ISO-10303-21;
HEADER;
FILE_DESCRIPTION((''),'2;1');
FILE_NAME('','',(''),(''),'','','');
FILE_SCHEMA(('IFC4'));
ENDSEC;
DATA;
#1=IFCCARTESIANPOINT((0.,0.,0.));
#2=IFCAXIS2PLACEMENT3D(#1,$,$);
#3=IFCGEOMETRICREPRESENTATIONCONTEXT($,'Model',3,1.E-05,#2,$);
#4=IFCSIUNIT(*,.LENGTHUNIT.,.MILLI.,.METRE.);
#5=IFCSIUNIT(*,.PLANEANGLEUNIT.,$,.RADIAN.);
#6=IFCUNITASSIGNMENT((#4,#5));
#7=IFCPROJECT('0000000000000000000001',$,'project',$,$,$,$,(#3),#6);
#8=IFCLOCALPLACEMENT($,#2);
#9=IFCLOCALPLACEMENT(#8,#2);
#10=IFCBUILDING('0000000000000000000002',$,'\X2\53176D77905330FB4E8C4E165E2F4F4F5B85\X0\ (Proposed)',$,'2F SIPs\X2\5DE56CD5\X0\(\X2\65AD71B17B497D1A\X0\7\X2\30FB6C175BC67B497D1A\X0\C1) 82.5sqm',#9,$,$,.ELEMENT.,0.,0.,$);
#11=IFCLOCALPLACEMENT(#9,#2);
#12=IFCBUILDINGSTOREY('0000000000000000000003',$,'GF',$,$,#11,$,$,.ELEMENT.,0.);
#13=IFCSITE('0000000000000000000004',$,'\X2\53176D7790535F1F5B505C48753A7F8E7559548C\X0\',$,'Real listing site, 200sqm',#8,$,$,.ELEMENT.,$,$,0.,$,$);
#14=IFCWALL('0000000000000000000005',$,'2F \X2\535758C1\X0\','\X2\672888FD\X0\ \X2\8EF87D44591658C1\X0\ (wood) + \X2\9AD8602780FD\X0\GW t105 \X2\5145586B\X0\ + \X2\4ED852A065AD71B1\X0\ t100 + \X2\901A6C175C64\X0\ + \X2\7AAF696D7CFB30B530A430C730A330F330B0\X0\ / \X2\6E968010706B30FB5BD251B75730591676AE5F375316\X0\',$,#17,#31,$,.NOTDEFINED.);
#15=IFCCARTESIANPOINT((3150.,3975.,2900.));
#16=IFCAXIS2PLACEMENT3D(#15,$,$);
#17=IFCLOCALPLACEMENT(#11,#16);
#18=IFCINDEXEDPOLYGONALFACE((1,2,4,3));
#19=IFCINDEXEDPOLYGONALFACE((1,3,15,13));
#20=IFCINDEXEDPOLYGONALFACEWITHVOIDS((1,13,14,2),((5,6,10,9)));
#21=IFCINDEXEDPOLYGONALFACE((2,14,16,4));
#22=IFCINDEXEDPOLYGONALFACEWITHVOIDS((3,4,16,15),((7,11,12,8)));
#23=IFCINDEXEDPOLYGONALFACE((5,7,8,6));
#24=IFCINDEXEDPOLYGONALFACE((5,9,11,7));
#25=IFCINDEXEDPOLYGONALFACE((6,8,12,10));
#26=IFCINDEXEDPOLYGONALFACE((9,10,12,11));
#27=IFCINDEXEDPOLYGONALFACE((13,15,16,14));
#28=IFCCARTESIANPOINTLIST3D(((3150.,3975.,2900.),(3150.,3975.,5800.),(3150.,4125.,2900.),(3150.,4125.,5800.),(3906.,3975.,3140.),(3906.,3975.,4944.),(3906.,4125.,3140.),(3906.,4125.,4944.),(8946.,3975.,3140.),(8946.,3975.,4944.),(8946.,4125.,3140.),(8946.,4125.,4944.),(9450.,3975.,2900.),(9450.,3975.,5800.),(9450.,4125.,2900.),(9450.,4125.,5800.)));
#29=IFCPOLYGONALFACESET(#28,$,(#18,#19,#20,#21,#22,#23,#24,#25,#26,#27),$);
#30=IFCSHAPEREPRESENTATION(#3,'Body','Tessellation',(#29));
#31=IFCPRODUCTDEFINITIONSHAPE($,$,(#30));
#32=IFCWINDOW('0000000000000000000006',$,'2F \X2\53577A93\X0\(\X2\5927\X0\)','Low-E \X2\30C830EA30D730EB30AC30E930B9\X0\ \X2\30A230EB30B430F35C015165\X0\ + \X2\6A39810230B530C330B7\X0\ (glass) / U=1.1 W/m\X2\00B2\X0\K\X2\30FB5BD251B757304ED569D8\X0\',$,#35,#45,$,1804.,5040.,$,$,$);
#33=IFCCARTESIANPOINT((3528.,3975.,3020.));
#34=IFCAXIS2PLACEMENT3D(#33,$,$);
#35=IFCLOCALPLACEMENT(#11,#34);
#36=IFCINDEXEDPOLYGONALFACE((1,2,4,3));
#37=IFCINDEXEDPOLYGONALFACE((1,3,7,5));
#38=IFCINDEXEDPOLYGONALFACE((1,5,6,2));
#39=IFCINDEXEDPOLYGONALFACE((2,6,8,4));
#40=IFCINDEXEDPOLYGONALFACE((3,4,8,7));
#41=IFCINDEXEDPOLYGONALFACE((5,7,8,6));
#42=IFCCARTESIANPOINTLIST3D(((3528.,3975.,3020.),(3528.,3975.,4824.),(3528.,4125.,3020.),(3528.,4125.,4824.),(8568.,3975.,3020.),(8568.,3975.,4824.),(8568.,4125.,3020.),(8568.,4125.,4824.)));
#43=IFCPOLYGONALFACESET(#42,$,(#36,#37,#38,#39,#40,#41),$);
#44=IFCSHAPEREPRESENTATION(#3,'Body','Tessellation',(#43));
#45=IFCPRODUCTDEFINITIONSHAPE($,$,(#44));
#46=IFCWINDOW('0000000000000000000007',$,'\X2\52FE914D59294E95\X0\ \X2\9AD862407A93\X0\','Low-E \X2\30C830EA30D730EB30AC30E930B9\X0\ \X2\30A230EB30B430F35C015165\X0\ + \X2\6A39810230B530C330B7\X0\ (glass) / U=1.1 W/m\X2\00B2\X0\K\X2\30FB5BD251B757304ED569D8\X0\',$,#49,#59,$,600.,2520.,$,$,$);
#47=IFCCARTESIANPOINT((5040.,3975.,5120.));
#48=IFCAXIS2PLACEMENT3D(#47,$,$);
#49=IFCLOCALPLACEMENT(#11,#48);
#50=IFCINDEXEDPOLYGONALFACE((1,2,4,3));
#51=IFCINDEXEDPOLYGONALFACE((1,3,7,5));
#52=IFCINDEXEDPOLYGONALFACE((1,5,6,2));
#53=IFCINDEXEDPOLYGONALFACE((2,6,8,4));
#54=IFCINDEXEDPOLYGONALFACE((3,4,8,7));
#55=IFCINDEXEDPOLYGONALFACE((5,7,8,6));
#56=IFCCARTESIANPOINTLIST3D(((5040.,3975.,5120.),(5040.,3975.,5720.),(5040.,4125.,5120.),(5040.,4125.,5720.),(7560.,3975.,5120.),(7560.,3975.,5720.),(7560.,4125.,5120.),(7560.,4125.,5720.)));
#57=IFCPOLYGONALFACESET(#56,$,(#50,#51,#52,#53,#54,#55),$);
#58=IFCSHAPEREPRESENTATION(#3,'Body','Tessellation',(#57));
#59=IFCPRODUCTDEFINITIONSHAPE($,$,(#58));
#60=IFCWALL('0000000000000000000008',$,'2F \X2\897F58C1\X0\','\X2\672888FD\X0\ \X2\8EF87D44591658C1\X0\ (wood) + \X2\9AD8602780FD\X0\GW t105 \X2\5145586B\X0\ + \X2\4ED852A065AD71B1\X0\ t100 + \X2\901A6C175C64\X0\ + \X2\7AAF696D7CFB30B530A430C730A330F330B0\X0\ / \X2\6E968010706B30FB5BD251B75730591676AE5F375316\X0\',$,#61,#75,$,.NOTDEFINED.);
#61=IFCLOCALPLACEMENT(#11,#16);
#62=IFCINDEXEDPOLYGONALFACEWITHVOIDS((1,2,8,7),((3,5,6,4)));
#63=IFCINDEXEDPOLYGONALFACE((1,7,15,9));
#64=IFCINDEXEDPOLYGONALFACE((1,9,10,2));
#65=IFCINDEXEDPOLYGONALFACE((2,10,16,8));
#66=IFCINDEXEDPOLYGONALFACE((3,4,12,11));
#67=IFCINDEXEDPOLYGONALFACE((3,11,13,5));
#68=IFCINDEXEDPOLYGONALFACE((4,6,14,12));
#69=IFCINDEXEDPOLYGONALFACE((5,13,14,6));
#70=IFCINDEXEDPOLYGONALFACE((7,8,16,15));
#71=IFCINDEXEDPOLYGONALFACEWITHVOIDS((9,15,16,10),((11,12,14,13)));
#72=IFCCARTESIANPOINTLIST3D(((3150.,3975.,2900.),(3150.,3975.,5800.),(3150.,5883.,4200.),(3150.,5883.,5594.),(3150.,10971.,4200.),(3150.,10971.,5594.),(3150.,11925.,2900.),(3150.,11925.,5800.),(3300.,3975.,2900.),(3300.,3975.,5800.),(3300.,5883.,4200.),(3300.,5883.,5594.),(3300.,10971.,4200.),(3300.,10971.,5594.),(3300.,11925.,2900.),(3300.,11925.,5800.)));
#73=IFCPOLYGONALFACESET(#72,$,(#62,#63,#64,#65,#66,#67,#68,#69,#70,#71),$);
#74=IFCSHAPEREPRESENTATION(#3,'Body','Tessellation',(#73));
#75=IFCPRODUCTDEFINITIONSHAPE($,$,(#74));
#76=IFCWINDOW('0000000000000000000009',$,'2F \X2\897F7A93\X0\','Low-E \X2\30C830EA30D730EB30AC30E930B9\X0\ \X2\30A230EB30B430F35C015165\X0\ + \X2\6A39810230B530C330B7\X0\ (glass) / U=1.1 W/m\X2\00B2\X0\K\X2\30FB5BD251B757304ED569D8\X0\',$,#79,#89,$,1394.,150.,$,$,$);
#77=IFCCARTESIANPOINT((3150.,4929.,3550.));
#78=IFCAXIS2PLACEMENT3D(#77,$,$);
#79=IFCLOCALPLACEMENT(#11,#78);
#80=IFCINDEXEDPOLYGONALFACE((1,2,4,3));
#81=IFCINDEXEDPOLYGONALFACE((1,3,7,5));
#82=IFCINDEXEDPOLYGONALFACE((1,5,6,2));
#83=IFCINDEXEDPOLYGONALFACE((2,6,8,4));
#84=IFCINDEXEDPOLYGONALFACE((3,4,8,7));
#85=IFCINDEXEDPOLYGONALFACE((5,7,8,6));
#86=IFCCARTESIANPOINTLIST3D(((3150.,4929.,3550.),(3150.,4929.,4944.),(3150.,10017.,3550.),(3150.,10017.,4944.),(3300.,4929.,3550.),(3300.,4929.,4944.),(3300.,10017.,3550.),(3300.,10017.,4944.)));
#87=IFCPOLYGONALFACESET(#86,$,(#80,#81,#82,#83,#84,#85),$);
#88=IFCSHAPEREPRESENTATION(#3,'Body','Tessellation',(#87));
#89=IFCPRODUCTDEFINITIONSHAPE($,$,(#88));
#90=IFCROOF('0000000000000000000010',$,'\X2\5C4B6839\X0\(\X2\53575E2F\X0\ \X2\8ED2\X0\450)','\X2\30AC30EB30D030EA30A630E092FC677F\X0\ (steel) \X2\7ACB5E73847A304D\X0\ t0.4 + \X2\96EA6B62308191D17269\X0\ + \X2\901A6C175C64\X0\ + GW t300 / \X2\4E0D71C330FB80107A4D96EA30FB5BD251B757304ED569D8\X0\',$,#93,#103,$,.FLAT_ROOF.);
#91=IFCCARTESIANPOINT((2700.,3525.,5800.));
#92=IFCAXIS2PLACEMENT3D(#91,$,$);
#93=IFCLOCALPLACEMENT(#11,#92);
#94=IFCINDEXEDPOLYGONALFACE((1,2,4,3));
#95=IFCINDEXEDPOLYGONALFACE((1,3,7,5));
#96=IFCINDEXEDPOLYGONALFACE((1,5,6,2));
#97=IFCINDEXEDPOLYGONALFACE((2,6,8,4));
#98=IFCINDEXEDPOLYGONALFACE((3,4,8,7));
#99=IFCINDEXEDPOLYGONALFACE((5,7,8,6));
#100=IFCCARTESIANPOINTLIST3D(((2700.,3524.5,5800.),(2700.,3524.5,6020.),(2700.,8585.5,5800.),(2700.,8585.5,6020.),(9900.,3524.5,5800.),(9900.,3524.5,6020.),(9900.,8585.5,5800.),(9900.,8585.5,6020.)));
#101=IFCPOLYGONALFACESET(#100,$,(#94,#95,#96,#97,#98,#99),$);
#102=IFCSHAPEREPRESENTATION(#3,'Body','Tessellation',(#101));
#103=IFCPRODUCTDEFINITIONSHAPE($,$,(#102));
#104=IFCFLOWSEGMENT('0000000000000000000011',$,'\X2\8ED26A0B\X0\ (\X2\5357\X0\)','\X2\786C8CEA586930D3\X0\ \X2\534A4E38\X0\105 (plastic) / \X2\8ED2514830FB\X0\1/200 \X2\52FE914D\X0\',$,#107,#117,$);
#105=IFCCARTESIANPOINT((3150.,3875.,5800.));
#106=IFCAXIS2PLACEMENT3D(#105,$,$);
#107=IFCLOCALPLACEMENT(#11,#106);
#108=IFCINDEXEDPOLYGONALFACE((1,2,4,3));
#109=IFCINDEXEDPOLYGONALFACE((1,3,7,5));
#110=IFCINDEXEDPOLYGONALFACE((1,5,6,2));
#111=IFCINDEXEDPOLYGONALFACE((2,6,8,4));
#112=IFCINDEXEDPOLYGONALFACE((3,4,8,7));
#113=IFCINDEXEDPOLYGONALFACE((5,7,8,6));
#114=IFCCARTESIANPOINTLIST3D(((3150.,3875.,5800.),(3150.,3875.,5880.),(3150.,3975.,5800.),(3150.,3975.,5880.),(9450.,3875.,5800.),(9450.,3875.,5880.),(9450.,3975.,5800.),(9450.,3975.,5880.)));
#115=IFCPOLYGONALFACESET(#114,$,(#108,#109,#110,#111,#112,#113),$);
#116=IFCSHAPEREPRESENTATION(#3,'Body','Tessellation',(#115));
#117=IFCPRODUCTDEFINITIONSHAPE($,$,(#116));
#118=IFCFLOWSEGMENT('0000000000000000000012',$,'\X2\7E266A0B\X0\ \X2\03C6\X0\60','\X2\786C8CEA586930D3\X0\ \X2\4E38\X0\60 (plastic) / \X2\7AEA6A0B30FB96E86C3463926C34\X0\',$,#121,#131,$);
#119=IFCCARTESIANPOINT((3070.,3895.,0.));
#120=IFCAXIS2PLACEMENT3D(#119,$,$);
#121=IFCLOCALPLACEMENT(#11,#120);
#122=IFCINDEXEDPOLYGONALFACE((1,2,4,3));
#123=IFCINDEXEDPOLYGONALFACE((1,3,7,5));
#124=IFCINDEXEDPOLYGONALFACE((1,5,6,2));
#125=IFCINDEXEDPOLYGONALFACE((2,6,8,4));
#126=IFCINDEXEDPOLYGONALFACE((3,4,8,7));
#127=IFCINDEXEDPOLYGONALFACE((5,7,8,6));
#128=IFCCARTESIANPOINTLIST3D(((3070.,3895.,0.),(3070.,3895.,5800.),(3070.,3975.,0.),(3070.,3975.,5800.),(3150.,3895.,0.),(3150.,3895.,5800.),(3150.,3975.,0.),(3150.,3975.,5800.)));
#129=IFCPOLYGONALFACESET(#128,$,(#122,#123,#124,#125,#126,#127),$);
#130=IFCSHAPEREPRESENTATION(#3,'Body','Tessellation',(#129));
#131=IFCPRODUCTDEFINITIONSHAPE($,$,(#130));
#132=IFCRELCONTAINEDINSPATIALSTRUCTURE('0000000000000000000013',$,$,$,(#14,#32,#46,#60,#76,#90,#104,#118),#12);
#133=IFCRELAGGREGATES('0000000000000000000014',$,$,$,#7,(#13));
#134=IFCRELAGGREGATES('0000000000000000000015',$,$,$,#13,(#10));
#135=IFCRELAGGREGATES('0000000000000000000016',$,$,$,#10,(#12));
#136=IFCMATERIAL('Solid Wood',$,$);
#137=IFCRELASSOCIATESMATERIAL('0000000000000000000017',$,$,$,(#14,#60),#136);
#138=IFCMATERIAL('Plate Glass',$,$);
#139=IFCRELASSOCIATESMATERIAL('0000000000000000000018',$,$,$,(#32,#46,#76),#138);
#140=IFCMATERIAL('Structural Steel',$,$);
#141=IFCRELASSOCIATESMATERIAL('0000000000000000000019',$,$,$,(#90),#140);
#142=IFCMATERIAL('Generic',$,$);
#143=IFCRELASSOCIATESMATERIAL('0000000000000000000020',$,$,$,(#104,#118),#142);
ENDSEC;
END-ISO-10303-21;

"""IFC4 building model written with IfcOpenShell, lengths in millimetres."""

from ifc_helpers import new_model, si_unit, frame, frame_2d, origin, place, context, project, spatial, rectangle, extrude, material, element, fill, save


model = new_model("IFC4")

# Units and contexts
model_context = context("Model", 3, precision=1e-05, world=origin())
ifc_project = project(units=[si_unit("LENGTHUNIT", "METRE", prefix="MILLI"), si_unit("PLANEANGLEUNIT", "RADIAN")], contexts=[model_context])

# Site, building, storey
site_placement = place(None, origin())
site = spatial("IfcSite", under=ifc_project, at=site_placement, Name="北海道弟子屈町美留和", ObjectType="Real listing site, 200sqm", CompositionType="ELEMENT", RefElevation=0.0)
building_placement = place(site_placement, origin())
building = spatial("IfcBuilding", under=site, at=building_placement, Name="北海道・二世帯住宅 (Proposed)", ObjectType="2F SIPs工法(断熱等級7・気密等級C1) 82.5sqm", CompositionType="ELEMENT", ElevationOfRefHeight=0.0, ElevationOfTerrain=0.0)
storey_placement = place(building_placement, origin())
storey = spatial("IfcBuildingStorey", under=building, at=storey_placement, Name="GF", CompositionType="ELEMENT", Elevation=0.0)

# Shared definitions
ifc_material_1 = material(Name="Solid Wood")

# Shared definitions
ifc_material_2 = material(Name="Plate Glass")

# Wall, openings, windows
wall_1_placement = place(storey_placement, frame((3150.0, 3975.0, 2900.0)))
wall_1 = element("IfcWall", 1, at=wall_1_placement, inside=storey, material=ifc_material_1, Name="2F 南壁", Description="木製 軸組外壁 (wood) + 高性能GW t105 充填 + 付加断熱 t100 + 通気層 + 窯業系サイディング / 準耐火・寒冷地外皮強化", PredefinedType="NOTDEFINED", context=model_context, shape_type="SweptSolid", body=[
    extrude(rectangle(XDim=6300.0, YDim=150.0, at=frame_2d((3150.0, 75.0))), frame((3150.0, 3975.0, 2900.0)), (0.0, 0.0, 1.0), 2900.0),
])
opening_1_placement = place(storey_placement, frame((3528.0, 3975.0, 3020.0)))
opening_1 = element("IfcOpeningElement", 2, at=opening_1_placement, cuts=wall_1, PredefinedType="NOTDEFINED", context=model_context, shape_type="SweptSolid", body=[
    extrude(rectangle(XDim=5040.0, YDim=150.0, at=frame_2d((2520.0, 75.0))), frame((3528.0, 3975.0, 3020.0)), (0.0, 0.0, 1.0), 1804.0),
])
opening_2_placement = place(storey_placement, frame((5040.0, 3975.0, 5120.0)))
opening_2 = element("IfcOpeningElement", 3, at=opening_2_placement, cuts=wall_1, PredefinedType="NOTDEFINED", context=model_context, shape_type="SweptSolid", body=[
    extrude(rectangle(XDim=2520.0, YDim=150.0, at=frame_2d((1260.0, 75.0))), frame((5040.0, 3975.0, 5120.0)), (0.0, 0.0, 1.0), 600.0),
])
window_1_placement = place(storey_placement, frame((3528.0, 3975.0, 3020.0)))
window_1 = element("IfcWindow", 4, at=window_1_placement, inside=storey, material=ifc_material_2, Name="2F 南窓(大)", Description="Low-E トリプルガラス アルゴン封入 + 樹脂サッシ (glass) / U=1.1 W/m²K・寒冷地仕様", OverallHeight=1804.0, OverallWidth=5040.0, context=model_context, shape_type="SweptSolid", body=[
    extrude(rectangle(XDim=5040.0, YDim=150.0, at=frame_2d((2520.0, 75.0))), frame((3528.0, 3975.0, 3020.0)), (0.0, 0.0, 1.0), 1804.0),
])
fill(opening_1, window_1)
window_2_placement = place(storey_placement, frame((5040.0, 3975.0, 5120.0)))
window_2 = element("IfcWindow", 5, at=window_2_placement, inside=storey, material=ifc_material_2, Name="勾配天井 高所窓", Description="Low-E トリプルガラス アルゴン封入 + 樹脂サッシ (glass) / U=1.1 W/m²K・寒冷地仕様", OverallHeight=600.0, OverallWidth=2520.0, context=model_context, shape_type="SweptSolid", body=[
    extrude(rectangle(XDim=2520.0, YDim=150.0, at=frame_2d((1260.0, 75.0))), frame((5040.0, 3975.0, 5120.0)), (0.0, 0.0, 1.0), 600.0),
])
fill(opening_2, window_2)

# Wall, opening, window
wall_2_placement = place(storey_placement, frame((3150.0, 3975.0, 2900.0)))
wall_2 = element("IfcWall", 6, at=wall_2_placement, inside=storey, material=ifc_material_1, Name="2F 西壁", Description="木製 軸組外壁 (wood) + 高性能GW t105 充填 + 付加断熱 t100 + 通気層 + 窯業系サイディング / 準耐火・寒冷地外皮強化", PredefinedType="NOTDEFINED", context=model_context, shape_type="SweptSolid", body=[
    extrude(rectangle(XDim=150.0, YDim=7950.0, at=frame_2d((75.0, 3975.0))), frame((3150.0, 3975.0, 2900.0)), (0.0, 0.0, 1.0), 2900.0),
])
opening_3_placement = place(storey_placement, frame((3150.0, 4929.0, 3550.0)))
opening_3 = element("IfcOpeningElement", 7, at=opening_3_placement, cuts=wall_2, PredefinedType="NOTDEFINED", context=model_context, shape_type="SweptSolid", body=[
    extrude(rectangle(XDim=150.0, YDim=5088.0, at=frame_2d((75.0, 2544.0))), frame((3150.0, 4929.0, 3550.0)), (0.0, 0.0, 1.0), 1394.0),
])
window_3_placement = place(storey_placement, frame((3150.0, 4929.0, 3550.0)))
window_3 = element("IfcWindow", 8, at=window_3_placement, inside=storey, material=ifc_material_2, Name="2F 西窓", Description="Low-E トリプルガラス アルゴン封入 + 樹脂サッシ (glass) / U=1.1 W/m²K・寒冷地仕様", OverallHeight=1394.0, OverallWidth=150.0, context=model_context, shape_type="SweptSolid", body=[
    extrude(rectangle(XDim=150.0, YDim=5088.0, at=frame_2d((75.0, 2544.0))), frame((3150.0, 4929.0, 3550.0)), (0.0, 0.0, 1.0), 1394.0),
])
fill(opening_3, window_3)

# Roof
ifc_material_3 = material(Name="Structural Steel")
for number, where, name in (
    (9, (2700.0, 3525.0, 5800.0), "屋根(南帯 軒450)"),
):
    element("IfcRoof", number, at=place(storey_placement, frame(where)), inside=storey, material=ifc_material_3, Name=name, Description="ガルバリウム鋼板 (steel) 立平葺き t0.4 + 雪止め金物 + 通気層 + GW t300 / 不燃・耐積雪・寒冷地仕様", PredefinedType="FLAT_ROOF", context=model_context, shape_type="SweptSolid", body=[
        extrude(rectangle(XDim=7200.0, YDim=5061.0, at=frame_2d((3600.0, 2530.0))), frame((2700.0, 3525.0, 5800.0)), (0.0, 0.0, 1.0), 220.0),
    ])

# Flow segments
ifc_material_4 = material(Name="Generic")
flow_segment_1_placement = place(storey_placement, frame((3150.0, 3875.0, 5800.0)))
element("IfcFlowSegment", 10, at=flow_segment_1_placement, inside=storey, material=ifc_material_4, Name="軒樋 (南)", Description="硬質塩ビ 半丸105 (plastic) / 軒先・1/200 勾配", context=model_context, shape_type="SweptSolid", body=[
    extrude(rectangle(XDim=6300.0, YDim=100.0, at=frame_2d((3150.0, 50.0))), frame((3150.0, 3875.0, 5800.0)), (0.0, 0.0, 1.0), 80.0),
])
flow_segment_2_placement = place(storey_placement, frame((3070.0, 3895.0, 0.0)))
element("IfcFlowSegment", 11, at=flow_segment_2_placement, inside=storey, material=ifc_material_4, Name="縦樋 φ60", Description="硬質塩ビ 丸60 (plastic) / 竪樋・雨水排水", context=model_context, shape_type="SweptSolid", body=[
    extrude(rectangle(XDim=80.0, YDim=80.0, at=frame_2d((40.0, 40.0))), frame((3070.0, 3895.0, 0.0)), (0.0, 0.0, 1.0), 5800.0),
])

save(model, "model.ifc")
